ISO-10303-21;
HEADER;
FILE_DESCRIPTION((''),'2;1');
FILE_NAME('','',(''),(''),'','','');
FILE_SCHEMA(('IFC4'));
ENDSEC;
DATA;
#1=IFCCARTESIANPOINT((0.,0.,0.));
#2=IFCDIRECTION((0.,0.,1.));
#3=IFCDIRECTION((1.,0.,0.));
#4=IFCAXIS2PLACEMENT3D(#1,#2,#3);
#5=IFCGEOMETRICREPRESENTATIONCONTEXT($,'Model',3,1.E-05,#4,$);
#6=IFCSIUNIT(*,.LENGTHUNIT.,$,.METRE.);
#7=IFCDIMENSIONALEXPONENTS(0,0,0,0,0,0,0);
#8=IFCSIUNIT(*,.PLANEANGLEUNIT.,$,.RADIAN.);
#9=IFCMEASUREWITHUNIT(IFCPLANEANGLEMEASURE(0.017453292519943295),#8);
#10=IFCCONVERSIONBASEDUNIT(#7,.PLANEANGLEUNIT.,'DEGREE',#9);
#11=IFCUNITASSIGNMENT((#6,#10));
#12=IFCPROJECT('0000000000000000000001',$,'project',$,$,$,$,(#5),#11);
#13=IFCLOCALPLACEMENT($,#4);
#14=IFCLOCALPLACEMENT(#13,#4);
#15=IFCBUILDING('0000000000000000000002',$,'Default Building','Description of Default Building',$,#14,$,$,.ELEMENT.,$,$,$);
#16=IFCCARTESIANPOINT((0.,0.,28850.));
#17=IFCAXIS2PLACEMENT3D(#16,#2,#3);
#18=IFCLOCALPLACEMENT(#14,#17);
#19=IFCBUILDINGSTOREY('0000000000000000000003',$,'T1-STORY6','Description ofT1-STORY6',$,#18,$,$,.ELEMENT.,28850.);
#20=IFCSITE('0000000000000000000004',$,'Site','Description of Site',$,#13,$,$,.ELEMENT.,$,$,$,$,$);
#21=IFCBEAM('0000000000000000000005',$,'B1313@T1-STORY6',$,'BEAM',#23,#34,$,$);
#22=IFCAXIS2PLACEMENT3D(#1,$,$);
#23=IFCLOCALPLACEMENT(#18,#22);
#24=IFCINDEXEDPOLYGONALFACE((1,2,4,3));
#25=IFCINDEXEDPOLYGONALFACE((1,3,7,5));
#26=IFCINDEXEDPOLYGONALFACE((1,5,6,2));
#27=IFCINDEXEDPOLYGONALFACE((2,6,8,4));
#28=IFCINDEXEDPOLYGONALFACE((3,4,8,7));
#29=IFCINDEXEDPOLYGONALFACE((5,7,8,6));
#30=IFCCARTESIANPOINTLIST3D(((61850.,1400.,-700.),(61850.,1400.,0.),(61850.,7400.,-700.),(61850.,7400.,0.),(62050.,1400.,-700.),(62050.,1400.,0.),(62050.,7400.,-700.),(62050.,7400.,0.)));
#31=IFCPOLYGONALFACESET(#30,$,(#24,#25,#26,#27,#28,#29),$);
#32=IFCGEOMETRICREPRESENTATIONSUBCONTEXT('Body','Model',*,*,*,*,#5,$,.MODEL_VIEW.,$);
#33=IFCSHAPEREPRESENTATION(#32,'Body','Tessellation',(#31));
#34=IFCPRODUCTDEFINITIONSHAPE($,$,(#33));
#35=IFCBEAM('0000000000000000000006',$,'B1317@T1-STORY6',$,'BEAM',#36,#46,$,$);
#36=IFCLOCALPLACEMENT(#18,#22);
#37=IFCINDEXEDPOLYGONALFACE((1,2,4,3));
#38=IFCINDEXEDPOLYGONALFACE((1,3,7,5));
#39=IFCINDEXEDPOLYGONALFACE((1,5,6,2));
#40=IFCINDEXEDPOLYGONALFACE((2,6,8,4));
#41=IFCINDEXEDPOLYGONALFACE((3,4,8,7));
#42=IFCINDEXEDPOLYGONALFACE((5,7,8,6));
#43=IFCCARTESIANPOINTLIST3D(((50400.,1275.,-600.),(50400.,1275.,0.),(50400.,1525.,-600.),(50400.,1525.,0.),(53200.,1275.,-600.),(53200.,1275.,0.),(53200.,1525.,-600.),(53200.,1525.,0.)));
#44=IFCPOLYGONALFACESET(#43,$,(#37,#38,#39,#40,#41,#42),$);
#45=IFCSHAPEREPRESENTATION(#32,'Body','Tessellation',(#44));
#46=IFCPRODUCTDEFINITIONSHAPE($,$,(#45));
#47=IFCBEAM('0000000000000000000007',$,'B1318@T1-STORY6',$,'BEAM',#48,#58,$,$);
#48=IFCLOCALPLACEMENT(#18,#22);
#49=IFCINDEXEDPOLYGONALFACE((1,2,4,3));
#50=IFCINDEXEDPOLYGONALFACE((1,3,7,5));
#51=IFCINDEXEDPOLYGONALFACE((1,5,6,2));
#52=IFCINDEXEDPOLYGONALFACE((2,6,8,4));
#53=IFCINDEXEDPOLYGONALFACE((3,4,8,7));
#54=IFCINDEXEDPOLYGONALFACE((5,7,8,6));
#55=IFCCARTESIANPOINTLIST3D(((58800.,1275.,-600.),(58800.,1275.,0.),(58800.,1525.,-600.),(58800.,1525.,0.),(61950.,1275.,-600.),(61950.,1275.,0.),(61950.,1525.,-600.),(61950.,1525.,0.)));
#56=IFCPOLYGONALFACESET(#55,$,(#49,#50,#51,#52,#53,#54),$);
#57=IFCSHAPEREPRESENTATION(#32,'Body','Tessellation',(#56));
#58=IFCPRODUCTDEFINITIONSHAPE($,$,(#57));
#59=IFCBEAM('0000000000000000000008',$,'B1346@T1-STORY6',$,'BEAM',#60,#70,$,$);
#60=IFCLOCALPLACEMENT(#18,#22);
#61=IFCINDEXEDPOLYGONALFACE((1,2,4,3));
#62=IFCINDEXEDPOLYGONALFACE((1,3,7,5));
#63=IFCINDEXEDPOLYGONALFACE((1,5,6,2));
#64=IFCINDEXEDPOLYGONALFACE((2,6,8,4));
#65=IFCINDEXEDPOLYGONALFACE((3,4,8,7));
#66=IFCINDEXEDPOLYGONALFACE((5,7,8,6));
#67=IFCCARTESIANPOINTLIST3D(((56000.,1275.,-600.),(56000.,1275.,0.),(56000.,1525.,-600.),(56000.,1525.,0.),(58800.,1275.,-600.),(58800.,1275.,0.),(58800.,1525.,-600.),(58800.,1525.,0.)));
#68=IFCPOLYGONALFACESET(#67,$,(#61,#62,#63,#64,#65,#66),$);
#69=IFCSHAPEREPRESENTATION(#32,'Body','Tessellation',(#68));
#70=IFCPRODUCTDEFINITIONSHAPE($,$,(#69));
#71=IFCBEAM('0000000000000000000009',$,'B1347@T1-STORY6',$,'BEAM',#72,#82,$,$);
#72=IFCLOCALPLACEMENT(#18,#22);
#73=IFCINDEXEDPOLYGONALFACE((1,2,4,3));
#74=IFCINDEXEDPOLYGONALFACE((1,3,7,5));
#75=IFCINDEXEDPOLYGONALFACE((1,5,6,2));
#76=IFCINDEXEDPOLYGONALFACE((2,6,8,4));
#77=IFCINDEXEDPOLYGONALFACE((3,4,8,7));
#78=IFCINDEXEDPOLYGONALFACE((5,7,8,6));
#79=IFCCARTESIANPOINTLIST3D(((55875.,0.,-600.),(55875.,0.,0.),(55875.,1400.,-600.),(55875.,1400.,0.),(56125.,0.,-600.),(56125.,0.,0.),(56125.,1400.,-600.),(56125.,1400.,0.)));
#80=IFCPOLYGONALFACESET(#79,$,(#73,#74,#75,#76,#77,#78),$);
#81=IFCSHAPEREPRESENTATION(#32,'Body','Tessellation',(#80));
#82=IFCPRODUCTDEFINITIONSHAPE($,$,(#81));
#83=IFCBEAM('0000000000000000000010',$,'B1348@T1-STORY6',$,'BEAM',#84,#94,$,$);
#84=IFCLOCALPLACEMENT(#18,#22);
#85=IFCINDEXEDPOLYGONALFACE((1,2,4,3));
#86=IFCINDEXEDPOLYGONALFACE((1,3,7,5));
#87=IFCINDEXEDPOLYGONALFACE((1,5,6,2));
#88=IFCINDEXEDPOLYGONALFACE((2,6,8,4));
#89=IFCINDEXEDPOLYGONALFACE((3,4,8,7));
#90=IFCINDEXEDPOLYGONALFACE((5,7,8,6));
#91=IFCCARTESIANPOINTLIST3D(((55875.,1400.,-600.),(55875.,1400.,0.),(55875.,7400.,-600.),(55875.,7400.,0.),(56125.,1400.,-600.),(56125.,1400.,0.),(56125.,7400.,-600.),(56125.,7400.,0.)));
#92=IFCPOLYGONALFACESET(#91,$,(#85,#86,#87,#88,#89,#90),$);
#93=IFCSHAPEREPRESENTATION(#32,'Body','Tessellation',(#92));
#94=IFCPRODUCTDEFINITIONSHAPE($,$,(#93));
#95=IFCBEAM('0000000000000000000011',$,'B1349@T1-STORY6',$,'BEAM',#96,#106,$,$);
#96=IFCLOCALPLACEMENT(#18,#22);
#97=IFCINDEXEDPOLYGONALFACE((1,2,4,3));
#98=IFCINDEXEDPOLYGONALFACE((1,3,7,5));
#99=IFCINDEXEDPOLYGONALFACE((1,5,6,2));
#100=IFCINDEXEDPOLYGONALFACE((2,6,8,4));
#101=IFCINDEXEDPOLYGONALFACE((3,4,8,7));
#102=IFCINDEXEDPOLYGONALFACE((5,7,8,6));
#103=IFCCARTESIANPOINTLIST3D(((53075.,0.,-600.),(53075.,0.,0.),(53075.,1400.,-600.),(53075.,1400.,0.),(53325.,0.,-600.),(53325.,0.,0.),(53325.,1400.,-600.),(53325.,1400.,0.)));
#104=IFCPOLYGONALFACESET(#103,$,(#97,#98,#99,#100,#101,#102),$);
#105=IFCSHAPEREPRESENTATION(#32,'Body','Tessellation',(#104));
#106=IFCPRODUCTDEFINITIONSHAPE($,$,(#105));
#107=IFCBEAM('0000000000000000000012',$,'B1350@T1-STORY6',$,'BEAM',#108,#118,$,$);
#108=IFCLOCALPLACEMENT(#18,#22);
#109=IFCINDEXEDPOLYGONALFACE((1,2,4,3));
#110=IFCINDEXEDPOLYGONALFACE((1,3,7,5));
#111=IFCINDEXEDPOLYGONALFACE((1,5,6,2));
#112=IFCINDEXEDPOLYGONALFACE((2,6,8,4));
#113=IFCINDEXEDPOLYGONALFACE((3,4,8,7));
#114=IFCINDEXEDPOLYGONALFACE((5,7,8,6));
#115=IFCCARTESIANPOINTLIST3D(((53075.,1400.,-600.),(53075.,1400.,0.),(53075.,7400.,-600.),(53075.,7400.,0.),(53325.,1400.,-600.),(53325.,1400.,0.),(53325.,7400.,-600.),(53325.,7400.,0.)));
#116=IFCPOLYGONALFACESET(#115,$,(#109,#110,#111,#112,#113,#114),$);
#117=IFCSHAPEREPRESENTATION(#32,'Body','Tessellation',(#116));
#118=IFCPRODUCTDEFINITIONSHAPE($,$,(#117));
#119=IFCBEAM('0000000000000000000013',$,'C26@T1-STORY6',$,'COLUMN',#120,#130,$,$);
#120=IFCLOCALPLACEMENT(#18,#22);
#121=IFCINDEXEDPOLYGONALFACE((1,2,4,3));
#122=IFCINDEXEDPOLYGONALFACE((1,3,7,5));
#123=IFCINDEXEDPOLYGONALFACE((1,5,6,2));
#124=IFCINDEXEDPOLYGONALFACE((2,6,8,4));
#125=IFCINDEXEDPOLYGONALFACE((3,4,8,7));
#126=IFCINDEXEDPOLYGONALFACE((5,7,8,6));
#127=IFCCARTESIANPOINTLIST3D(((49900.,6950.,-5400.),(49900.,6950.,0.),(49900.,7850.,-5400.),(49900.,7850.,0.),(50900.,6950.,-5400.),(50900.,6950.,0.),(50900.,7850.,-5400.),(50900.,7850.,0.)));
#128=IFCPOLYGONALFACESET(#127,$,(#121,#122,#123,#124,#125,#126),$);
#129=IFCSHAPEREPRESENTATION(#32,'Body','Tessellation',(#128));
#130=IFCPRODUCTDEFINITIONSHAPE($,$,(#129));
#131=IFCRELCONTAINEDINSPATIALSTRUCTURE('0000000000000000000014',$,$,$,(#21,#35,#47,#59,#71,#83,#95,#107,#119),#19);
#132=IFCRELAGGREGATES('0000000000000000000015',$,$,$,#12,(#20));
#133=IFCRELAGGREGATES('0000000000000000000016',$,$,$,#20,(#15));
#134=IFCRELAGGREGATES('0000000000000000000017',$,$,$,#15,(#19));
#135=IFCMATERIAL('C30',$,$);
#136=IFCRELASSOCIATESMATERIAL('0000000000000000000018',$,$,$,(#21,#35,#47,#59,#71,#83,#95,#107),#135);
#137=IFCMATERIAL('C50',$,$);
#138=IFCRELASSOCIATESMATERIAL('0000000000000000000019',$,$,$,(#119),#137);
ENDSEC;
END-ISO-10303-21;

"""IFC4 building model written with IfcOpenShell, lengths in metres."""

from ifc_helpers import new_model, entity, si_unit, converted_unit, frame, origin_with_axes, place, context, subcontext, project, spatial, rectangle, extrude, material, element, save


model = new_model("IFC4")

# Units and contexts
model_context = context("Model", 3, precision=1e-05, world=origin_with_axes())
body_context = subcontext(model_context, "Body", "Model", "MODEL_VIEW")
ifc_project = project(units=[si_unit("LENGTHUNIT", "METRE"), converted_unit("PLANEANGLEUNIT", "DEGREE", entity("IfcPlaneAngleMeasure", 0.017453292519943295), si_unit("PLANEANGLEUNIT", "RADIAN"), dimensions=[0, 0, 0, 0, 0, 0, 0])], contexts=[model_context])

# Site, building, storey
site_placement = place(None, origin_with_axes())
site = spatial("IfcSite", under=ifc_project, at=site_placement, Name="Site", Description="Description of Site", CompositionType="ELEMENT")
building_placement = place(site_placement, origin_with_axes())
building = spatial("IfcBuilding", under=site, at=building_placement, Name="Default Building", Description="Description of Default Building", CompositionType="ELEMENT")
storey_placement = place(building_placement, frame((0.0, 0.0, 28850.0), z_axis=(0.0, 0.0, 1.0), x_axis=(1.0, 0.0, 0.0)))
storey = spatial("IfcBuildingStorey", under=building, at=storey_placement, Name="T1-STORY6", Description="Description ofT1-STORY6", CompositionType="ELEMENT", Elevation=28850.0)

# Beams
ifc_material_1 = material(Name="C30")
ifc_material_2 = material(Name="C50")
beam_1_placement = place(storey_placement, frame((61950.0, 1400.0, -350.0), z_axis=(0.0, 1.0, 0.0), x_axis=(-1.0, 0.0, 0.0)))
element("IfcBeam", 1, at=beam_1_placement, inside=storey, material=ifc_material_1, Name="B1313@T1-STORY6", ObjectType="BEAM", context=body_context, shape_type="SweptSolid", body=[
    extrude(rectangle(XDim=200.0, YDim=700.0), origin_with_axes(), (0.0, 0.0, 1.0), 6000.0),
])
beam_2_placement = place(storey_placement, frame((50400.0, 1400.0, -300.0), z_axis=(1.0, 0.0, 0.0), x_axis=(0.0, 1.0, 0.0)))
element("IfcBeam", 2, at=beam_2_placement, inside=storey, material=ifc_material_1, Name="B1317@T1-STORY6", ObjectType="BEAM", context=body_context, shape_type="SweptSolid", body=[
    extrude(rectangle(XDim=250.0, YDim=600.0), origin_with_axes(), (0.0, 0.0, 1.0), 2800.0),
])
beam_3_placement = place(storey_placement, frame((58800.0, 1400.0, -300.0), z_axis=(1.0, 0.0, 0.0), x_axis=(0.0, 1.0, 0.0)))
element("IfcBeam", 3, at=beam_3_placement, inside=storey, material=ifc_material_1, Name="B1318@T1-STORY6", ObjectType="BEAM", context=body_context, shape_type="SweptSolid", body=[
    extrude(rectangle(XDim=250.0, YDim=600.0), origin_with_axes(), (0.0, 0.0, 1.0), 3150.0),
])
beam_4_placement = place(storey_placement, frame((56000.0, 1400.0, -300.0), z_axis=(1.0, 0.0, 0.0), x_axis=(0.0, 1.0, 0.0)))
element("IfcBeam", 4, at=beam_4_placement, inside=storey, material=ifc_material_1, Name="B1346@T1-STORY6", ObjectType="BEAM", context=body_context, shape_type="SweptSolid", body=[
    extrude(rectangle(XDim=250.0, YDim=600.0), origin_with_axes(), (0.0, 0.0, 1.0), 2800.0),
])
beam_5_placement = place(storey_placement, frame((56000.0, 0.0, -300.0), z_axis=(0.0, 1.0, 0.0), x_axis=(-1.0, 0.0, 0.0)))
element("IfcBeam", 5, at=beam_5_placement, inside=storey, material=ifc_material_1, Name="B1347@T1-STORY6", ObjectType="BEAM", context=body_context, shape_type="SweptSolid", body=[
    extrude(rectangle(XDim=250.0, YDim=600.0), origin_with_axes(), (0.0, 0.0, 1.0), 1400.0),
])
beam_6_placement = place(storey_placement, frame((56000.0, 1400.0, -300.0), z_axis=(0.0, 1.0, 0.0), x_axis=(-1.0, 0.0, 0.0)))
element("IfcBeam", 6, at=beam_6_placement, inside=storey, material=ifc_material_1, Name="B1348@T1-STORY6", ObjectType="BEAM", context=body_context, shape_type="SweptSolid", body=[
    extrude(rectangle(XDim=250.0, YDim=600.0), origin_with_axes(), (0.0, 0.0, 1.0), 6000.0),
])
beam_7_placement = place(storey_placement, frame((53200.0, 0.0, -300.0), z_axis=(0.0, 1.0, 0.0), x_axis=(-1.0, 0.0, 0.0)))
element("IfcBeam", 7, at=beam_7_placement, inside=storey, material=ifc_material_1, Name="B1349@T1-STORY6", ObjectType="BEAM", context=body_context, shape_type="SweptSolid", body=[
    extrude(rectangle(XDim=250.0, YDim=600.0), origin_with_axes(), (0.0, 0.0, 1.0), 1400.0),
])
beam_8_placement = place(storey_placement, frame((53200.0, 1400.0, -300.0), z_axis=(0.0, 1.0, 0.0), x_axis=(-1.0, 0.0, 0.0)))
element("IfcBeam", 8, at=beam_8_placement, inside=storey, material=ifc_material_1, Name="B1350@T1-STORY6", ObjectType="BEAM", context=body_context, shape_type="SweptSolid", body=[
    extrude(rectangle(XDim=250.0, YDim=600.0), origin_with_axes(), (0.0, 0.0, 1.0), 6000.0),
])
beam_9_placement = place(storey_placement, frame((50400.0, 7400.0, -5400.0), z_axis=(0.0, 0.0, 1.0), x_axis=(-1.0, 0.0, 0.0)))
element("IfcBeam", 9, at=beam_9_placement, inside=storey, material=ifc_material_2, Name="C26@T1-STORY6", ObjectType="COLUMN", context=body_context, shape_type="SweptSolid", body=[
    extrude(rectangle(XDim=1000.0, YDim=900.0), origin_with_axes(), (0.0, 0.0, 1.0), 5400.0),
])

save(model, "model.ifc")
